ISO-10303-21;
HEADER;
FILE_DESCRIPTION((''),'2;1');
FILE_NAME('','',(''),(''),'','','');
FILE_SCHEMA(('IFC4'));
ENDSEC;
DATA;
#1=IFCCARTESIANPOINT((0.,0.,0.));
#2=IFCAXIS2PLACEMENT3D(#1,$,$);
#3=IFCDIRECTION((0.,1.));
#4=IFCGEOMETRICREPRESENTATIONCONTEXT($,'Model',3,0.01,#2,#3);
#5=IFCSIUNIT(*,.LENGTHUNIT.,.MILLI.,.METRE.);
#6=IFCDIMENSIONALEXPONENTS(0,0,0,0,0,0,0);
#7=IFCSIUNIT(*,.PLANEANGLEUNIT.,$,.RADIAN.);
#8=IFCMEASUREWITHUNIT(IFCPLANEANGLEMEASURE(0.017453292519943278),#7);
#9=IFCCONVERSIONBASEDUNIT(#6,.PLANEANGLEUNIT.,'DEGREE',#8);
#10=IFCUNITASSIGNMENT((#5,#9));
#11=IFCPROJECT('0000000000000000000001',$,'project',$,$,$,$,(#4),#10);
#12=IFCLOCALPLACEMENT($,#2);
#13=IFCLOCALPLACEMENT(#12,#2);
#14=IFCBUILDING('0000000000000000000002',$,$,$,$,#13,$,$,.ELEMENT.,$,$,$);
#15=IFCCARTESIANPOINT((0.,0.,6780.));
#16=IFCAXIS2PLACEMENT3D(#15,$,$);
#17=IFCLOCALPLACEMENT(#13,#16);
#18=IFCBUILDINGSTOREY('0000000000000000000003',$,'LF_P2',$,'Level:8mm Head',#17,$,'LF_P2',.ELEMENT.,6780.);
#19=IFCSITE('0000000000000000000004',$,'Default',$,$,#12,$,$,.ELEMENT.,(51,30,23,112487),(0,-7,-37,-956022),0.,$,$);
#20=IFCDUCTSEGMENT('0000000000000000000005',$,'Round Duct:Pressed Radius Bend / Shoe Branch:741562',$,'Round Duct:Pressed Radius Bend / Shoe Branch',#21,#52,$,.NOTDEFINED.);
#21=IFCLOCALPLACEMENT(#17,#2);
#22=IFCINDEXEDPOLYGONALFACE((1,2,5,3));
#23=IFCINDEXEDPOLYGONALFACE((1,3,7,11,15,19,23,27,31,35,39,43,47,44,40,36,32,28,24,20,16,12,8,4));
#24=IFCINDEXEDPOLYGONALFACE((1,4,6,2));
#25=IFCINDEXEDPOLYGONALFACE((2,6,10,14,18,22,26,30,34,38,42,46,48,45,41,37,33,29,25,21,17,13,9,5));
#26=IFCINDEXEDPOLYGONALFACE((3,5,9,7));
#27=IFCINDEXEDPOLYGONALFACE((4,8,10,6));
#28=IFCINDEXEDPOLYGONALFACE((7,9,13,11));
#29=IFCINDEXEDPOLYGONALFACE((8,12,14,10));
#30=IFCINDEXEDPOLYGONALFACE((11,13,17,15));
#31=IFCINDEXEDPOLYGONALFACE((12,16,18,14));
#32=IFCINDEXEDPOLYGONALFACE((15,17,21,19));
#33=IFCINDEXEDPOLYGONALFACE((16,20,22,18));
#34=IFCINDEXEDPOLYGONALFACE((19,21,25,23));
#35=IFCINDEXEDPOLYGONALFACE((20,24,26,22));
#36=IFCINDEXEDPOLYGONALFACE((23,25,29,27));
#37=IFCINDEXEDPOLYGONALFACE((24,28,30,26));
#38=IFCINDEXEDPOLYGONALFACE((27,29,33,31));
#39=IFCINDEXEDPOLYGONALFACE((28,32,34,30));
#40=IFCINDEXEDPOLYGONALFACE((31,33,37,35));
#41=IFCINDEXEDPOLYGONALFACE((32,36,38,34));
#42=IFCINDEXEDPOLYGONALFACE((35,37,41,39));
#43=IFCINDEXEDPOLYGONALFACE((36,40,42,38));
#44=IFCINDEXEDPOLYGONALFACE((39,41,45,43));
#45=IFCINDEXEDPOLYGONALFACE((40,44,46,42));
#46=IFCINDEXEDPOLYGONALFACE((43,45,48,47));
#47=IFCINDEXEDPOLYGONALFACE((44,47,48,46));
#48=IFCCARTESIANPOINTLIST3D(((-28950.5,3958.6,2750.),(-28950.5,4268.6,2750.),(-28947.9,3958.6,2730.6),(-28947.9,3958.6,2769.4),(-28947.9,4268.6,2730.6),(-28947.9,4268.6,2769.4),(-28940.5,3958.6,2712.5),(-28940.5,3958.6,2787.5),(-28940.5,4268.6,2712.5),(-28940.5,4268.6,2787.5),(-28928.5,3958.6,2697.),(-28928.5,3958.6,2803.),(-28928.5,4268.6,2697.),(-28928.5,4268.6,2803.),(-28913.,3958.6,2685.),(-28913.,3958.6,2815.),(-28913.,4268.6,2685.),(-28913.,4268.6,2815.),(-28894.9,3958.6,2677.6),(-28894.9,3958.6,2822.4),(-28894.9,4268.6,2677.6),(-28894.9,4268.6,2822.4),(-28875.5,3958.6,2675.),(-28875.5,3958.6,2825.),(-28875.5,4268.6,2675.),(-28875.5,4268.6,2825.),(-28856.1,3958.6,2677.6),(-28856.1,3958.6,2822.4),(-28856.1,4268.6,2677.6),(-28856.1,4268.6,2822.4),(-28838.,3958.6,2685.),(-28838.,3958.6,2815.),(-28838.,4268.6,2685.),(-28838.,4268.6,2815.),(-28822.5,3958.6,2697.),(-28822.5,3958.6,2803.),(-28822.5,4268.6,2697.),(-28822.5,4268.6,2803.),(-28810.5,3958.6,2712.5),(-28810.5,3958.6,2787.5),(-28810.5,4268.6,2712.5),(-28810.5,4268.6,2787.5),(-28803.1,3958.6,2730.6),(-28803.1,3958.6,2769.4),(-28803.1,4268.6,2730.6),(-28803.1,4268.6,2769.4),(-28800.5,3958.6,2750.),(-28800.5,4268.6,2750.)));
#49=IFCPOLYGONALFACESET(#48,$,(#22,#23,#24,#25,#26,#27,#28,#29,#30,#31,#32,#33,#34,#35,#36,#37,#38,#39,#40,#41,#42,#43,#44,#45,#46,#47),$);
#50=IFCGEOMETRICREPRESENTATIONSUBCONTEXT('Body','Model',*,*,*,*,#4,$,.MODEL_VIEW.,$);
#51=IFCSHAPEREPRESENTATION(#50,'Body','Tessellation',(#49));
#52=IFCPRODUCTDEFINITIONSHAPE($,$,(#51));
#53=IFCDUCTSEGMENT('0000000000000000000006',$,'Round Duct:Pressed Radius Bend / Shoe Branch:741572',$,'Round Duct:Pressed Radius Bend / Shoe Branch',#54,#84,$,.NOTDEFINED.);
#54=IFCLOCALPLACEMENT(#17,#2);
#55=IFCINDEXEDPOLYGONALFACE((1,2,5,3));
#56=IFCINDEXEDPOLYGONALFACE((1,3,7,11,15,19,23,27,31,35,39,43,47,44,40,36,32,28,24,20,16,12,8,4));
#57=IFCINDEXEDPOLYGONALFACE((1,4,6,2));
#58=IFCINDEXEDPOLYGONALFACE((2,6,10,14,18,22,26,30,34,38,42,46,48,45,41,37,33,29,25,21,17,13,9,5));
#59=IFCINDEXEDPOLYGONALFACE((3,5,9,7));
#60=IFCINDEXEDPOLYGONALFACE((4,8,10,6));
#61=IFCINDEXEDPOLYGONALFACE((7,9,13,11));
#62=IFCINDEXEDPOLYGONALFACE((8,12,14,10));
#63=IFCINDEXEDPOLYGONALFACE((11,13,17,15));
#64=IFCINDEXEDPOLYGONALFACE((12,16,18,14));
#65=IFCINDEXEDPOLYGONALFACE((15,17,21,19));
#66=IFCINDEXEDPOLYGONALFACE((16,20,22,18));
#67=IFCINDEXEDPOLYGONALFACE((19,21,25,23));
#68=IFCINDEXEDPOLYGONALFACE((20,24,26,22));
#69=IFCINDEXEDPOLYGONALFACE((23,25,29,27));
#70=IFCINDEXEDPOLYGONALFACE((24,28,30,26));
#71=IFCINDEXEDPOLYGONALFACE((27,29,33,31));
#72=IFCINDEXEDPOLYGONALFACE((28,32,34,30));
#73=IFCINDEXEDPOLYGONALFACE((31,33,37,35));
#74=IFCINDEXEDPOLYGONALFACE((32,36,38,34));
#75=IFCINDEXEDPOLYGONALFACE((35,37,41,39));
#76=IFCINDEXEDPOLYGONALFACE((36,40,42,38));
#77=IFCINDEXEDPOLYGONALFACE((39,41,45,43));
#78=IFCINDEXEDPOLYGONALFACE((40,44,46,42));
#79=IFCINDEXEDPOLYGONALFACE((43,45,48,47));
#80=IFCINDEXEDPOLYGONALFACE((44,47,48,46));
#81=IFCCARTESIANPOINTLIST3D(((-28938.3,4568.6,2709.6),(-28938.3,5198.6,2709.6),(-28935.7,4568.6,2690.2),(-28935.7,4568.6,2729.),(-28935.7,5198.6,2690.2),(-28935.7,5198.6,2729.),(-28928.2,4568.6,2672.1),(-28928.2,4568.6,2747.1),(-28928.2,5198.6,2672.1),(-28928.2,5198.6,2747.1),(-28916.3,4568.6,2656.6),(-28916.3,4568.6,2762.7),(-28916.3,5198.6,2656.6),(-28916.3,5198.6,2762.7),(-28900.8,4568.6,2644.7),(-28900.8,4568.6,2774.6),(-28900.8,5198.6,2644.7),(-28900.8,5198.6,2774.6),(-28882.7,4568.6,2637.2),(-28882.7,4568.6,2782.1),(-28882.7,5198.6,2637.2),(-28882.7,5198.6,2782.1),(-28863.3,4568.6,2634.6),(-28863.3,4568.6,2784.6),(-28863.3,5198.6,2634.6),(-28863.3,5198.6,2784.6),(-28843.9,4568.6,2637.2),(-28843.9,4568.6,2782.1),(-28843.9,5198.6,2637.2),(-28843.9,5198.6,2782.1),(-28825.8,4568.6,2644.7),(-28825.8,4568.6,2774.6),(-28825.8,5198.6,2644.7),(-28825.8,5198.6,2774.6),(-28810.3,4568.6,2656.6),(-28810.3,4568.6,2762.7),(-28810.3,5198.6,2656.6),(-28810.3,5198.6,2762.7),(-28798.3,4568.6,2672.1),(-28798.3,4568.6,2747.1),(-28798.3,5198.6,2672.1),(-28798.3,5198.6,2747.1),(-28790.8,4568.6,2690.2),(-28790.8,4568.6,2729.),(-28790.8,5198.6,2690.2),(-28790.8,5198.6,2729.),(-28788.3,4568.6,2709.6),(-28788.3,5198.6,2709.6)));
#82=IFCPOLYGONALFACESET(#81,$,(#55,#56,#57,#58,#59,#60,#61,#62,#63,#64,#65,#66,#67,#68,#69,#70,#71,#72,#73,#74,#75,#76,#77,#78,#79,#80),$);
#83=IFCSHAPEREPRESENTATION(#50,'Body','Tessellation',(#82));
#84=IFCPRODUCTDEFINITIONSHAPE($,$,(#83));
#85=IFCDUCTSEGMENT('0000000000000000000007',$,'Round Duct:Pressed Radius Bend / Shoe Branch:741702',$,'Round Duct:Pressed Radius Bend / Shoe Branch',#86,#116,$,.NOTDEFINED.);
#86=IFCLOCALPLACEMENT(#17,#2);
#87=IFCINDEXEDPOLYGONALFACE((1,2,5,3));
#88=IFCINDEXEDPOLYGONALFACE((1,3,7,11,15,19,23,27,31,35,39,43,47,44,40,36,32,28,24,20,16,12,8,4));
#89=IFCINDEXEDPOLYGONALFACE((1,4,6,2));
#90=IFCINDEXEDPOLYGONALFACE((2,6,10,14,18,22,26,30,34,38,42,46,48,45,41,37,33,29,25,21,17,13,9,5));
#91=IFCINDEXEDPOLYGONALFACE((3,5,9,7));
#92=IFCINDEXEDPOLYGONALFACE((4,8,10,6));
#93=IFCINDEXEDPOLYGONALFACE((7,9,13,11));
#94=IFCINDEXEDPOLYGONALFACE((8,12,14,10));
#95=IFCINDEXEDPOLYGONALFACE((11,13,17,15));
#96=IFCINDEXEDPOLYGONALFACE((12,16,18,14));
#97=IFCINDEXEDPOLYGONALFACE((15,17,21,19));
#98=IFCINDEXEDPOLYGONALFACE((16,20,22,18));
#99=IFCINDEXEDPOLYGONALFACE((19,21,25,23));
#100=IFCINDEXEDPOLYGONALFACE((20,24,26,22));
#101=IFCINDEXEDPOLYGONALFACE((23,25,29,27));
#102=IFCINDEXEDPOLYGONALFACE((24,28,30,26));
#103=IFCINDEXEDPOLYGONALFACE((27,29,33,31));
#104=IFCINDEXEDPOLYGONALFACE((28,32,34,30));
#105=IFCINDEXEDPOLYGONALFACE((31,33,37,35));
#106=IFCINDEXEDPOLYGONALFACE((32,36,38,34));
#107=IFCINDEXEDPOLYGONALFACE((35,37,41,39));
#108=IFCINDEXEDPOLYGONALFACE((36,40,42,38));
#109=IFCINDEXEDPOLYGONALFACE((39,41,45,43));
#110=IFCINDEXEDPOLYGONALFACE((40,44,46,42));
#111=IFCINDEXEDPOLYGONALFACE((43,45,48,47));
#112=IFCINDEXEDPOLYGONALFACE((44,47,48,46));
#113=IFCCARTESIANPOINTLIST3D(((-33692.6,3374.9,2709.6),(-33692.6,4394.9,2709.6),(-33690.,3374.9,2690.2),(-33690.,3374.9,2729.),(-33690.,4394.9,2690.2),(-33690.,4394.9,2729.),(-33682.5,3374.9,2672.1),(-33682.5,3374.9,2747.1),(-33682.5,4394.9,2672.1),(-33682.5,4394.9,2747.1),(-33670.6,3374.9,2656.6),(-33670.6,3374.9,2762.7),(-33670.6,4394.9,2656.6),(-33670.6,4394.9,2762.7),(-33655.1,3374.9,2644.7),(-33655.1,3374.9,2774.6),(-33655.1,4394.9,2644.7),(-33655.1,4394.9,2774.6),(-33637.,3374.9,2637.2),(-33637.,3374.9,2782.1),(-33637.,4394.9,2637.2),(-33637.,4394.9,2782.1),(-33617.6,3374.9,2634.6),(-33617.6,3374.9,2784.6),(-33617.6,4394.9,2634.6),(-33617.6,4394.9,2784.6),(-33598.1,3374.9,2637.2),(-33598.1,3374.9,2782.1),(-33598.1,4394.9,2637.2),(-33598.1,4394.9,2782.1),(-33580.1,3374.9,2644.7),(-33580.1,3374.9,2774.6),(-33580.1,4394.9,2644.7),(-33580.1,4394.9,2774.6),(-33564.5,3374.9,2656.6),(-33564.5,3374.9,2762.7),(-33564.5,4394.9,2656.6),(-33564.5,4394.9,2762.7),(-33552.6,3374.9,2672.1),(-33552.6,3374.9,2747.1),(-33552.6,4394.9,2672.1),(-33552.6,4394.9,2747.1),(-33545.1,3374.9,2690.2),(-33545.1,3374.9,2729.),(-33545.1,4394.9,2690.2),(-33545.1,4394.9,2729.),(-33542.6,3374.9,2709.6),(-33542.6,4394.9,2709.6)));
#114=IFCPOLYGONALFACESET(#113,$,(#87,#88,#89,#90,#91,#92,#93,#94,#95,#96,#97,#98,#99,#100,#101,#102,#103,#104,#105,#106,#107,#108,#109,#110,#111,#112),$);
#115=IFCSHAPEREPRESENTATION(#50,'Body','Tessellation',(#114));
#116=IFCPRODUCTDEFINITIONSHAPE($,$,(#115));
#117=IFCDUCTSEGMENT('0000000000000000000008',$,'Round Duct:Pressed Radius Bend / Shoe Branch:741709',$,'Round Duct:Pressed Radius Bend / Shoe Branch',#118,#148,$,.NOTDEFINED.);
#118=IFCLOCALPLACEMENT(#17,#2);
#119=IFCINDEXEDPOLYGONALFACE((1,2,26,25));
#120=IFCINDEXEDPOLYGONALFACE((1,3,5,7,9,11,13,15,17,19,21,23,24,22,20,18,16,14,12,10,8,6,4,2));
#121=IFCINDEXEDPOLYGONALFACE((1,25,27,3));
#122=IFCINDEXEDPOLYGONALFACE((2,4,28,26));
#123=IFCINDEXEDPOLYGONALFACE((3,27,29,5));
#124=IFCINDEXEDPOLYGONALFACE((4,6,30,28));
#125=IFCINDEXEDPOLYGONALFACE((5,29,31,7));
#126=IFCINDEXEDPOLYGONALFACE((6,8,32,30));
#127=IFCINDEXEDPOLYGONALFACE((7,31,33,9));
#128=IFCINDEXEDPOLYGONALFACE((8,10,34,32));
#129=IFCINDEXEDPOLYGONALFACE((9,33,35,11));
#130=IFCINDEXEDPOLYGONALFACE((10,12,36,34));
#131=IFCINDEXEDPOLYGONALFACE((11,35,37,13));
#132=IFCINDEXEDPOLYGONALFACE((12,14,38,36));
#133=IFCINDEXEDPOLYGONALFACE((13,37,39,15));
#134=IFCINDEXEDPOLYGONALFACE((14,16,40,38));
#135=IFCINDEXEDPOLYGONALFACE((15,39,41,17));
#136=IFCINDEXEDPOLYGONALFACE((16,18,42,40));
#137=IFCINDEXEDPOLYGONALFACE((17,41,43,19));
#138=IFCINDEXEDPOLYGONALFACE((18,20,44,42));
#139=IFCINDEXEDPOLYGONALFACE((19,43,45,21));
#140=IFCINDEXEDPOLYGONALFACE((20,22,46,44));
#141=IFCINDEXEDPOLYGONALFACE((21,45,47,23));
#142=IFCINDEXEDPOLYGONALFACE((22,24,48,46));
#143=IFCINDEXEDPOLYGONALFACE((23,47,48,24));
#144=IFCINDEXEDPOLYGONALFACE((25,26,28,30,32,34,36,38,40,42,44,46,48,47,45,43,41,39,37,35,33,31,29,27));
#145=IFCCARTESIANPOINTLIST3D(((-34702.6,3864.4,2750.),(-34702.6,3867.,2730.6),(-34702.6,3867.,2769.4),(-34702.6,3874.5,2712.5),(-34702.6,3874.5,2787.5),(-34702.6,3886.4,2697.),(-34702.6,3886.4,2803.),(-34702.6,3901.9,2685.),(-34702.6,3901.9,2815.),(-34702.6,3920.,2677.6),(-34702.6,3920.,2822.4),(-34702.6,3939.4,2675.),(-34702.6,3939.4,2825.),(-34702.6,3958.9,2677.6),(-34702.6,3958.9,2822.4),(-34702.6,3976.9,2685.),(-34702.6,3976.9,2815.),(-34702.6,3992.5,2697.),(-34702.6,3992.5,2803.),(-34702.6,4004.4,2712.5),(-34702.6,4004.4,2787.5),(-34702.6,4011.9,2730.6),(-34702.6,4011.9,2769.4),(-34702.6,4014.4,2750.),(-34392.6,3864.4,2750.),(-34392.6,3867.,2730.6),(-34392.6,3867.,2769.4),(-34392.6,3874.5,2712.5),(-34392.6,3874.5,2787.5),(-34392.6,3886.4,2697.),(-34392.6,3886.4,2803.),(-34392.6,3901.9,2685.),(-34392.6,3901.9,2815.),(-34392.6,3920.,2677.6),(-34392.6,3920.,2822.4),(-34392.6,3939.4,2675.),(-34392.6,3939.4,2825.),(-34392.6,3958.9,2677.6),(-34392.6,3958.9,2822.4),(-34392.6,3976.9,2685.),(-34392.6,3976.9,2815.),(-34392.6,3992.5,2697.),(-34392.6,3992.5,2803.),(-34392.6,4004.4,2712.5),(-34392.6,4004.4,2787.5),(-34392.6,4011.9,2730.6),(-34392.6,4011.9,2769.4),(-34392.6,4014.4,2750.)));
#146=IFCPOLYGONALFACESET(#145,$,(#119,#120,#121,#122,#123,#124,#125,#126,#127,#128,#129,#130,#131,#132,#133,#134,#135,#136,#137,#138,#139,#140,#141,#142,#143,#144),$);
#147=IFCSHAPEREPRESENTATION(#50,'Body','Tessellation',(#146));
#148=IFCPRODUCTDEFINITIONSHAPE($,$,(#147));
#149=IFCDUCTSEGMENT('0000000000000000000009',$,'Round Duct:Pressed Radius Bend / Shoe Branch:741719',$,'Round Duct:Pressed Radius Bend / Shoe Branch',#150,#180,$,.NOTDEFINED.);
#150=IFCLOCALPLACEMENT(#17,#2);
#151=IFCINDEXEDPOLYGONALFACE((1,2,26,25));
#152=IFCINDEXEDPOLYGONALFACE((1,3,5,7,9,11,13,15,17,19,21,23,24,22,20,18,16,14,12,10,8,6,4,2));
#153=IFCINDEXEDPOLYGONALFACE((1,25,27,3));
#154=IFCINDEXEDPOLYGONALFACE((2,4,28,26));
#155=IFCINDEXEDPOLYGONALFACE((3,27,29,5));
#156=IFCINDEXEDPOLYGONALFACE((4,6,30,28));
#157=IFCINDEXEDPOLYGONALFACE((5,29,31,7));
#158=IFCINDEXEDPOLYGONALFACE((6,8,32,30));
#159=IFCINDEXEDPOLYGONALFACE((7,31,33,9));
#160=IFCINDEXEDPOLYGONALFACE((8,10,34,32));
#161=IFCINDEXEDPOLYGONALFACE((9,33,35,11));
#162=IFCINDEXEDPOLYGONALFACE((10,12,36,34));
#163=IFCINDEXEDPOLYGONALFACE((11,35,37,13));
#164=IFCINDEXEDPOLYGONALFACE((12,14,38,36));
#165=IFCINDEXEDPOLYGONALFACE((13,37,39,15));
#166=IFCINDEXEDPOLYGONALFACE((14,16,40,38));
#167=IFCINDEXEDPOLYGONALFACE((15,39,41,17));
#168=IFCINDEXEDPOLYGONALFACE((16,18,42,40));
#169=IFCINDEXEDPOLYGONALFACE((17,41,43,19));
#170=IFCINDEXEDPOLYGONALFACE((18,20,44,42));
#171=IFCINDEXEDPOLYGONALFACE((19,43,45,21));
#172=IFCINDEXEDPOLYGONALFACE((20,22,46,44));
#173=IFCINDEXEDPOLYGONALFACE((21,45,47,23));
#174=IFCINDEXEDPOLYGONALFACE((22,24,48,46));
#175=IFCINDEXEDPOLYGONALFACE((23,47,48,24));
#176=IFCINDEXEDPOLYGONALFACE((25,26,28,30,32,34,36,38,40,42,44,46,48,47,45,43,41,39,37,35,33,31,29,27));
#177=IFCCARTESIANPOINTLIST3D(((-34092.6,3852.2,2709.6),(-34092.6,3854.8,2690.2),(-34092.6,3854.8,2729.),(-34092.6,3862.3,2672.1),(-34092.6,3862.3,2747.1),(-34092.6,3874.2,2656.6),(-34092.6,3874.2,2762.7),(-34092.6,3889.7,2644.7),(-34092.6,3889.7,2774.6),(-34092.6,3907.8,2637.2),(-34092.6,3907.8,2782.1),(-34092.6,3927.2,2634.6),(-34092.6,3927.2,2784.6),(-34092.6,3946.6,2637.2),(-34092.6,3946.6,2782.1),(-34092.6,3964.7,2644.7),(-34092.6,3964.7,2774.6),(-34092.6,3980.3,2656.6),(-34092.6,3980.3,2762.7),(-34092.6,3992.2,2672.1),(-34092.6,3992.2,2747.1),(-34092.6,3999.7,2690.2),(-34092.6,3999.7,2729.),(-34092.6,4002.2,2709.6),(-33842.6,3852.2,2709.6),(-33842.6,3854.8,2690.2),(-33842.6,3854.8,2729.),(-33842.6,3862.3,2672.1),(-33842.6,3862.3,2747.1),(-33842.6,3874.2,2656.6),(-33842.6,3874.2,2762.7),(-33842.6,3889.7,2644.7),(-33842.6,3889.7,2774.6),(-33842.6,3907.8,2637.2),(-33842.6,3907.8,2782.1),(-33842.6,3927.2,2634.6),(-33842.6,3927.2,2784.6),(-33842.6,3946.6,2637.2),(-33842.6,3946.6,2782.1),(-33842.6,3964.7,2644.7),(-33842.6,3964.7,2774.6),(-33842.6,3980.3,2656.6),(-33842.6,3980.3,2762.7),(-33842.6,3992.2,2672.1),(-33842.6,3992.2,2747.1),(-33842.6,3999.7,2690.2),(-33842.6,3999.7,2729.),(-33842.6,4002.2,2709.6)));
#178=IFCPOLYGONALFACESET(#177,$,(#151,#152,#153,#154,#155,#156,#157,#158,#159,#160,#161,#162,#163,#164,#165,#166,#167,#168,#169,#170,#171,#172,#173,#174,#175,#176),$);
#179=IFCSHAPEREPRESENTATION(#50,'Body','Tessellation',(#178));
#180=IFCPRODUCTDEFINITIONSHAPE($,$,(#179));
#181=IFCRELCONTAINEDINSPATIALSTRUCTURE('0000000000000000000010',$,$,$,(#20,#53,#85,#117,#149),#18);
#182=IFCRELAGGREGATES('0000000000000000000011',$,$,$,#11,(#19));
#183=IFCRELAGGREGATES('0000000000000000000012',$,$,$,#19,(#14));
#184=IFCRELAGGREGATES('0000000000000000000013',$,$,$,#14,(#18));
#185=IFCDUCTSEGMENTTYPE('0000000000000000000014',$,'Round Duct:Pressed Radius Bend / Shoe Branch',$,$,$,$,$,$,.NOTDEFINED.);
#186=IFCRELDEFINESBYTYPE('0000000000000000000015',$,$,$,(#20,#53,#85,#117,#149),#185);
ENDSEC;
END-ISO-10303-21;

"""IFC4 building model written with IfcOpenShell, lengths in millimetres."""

from ifc_helpers import new_model, entity, si_unit, converted_unit, direction, frame, origin, place, context, subcontext, project, spatial, arc, indexed_curve, outline, extrude, type_object, element, save


model = new_model("IFC4")

# Units and contexts
model_context = context("Model", 3, precision=0.01, world=origin(), true_north=direction((0.0, 1.0)))
body_context = subcontext(model_context, "Body", "Model", "MODEL_VIEW")
ifc_project = project(units=[si_unit("LENGTHUNIT", "METRE", prefix="MILLI"), converted_unit("PLANEANGLEUNIT", "DEGREE", entity("IfcPlaneAngleMeasure", 0.017453292519943278), si_unit("PLANEANGLEUNIT", "RADIAN"), dimensions=[0, 0, 0, 0, 0, 0, 0])], contexts=[model_context])

# Site, building, storey
site_placement = place(None, origin())
site = spatial("IfcSite", under=ifc_project, at=site_placement, Name="Default", CompositionType="ELEMENT", RefLatitude=(51, 30, 23, 112487), RefLongitude=(0, -7, -37, -956022), RefElevation=0.0)
building_placement = place(site_placement, origin())
building = spatial("IfcBuilding", under=site, at=building_placement, CompositionType="ELEMENT")
storey_placement = place(building_placement, frame((0.0, 0.0, 6780.0)))
storey = spatial("IfcBuildingStorey", under=building, at=storey_placement, Name="LF_P2", ObjectType="Level:8mm Head", LongName="LF_P2", CompositionType="ELEMENT", Elevation=6780.0)

# Duct segments
duct_segment_type_1 = type_object("IfcDuctSegmentType", Name="Round Duct:Pressed Radius Bend / Shoe Branch", PredefinedType="NOTDEFINED")
duct_segment_1_placement = place(storey_placement, origin())
element("IfcDuctSegment", 1, at=duct_segment_1_placement, inside=storey, type_object=duct_segment_type_1, Name="Round Duct:Pressed Radius Bend / Shoe Branch:741562", ObjectType="Round Duct:Pressed Radius Bend / Shoe Branch", PredefinedType="NOTDEFINED", context=body_context, shape_type="SweptSolid", body=[
    extrude(outline(indexed_curve([(75.0, 0.0), (53.0, 53.0), (0.0, 75.0), (-53.0, 53.0), (-75.0, 0.0), (-53.0, -53.0), (0.0, -75.0), (53.0, -53.0)], segments=[arc(1, 2, 3), arc(3, 4, 5), arc(5, 6, 7), arc(7, 8, 1)], self_intersect=False)), frame((-28875.5, 3958.6, 2750.0), z_axis=(0.0, 1.0, 0.0), x_axis=(1.0, 0.0, 0.0)), (0.0, 0.0, 1.0), 310.0),
])
duct_segment_2_placement = place(storey_placement, origin())
element("IfcDuctSegment", 2, at=duct_segment_2_placement, inside=storey, type_object=duct_segment_type_1, Name="Round Duct:Pressed Radius Bend / Shoe Branch:741572", ObjectType="Round Duct:Pressed Radius Bend / Shoe Branch", PredefinedType="NOTDEFINED", context=body_context, shape_type="SweptSolid", body=[
    extrude(outline(indexed_curve([(75.0, 0.0), (53.0, 53.0), (0.0, 75.0), (-53.0, 53.0), (-75.0, 0.0), (-53.0, -53.0), (0.0, -75.0), (53.0, -53.0)], segments=[arc(1, 2, 3), arc(3, 4, 5), arc(5, 6, 7), arc(7, 8, 1)], self_intersect=False)), frame((-28863.3, 4568.6, 2709.6), z_axis=(0.0, 1.0, 0.0), x_axis=(-1.0, 0.0, 0.0)), (0.0, 0.0, 1.0), 630.0),
])
duct_segment_3_placement = place(storey_placement, origin())
element("IfcDuctSegment", 3, at=duct_segment_3_placement, inside=storey, type_object=duct_segment_type_1, Name="Round Duct:Pressed Radius Bend / Shoe Branch:741702", ObjectType="Round Duct:Pressed Radius Bend / Shoe Branch", PredefinedType="NOTDEFINED", context=body_context, shape_type="SweptSolid", body=[
    extrude(outline(indexed_curve([(75.0, 0.0), (53.0, 53.0), (0.0, 75.0), (-53.0, 53.0), (-75.0, 0.0), (-53.0, -53.0), (0.0, -75.0), (53.0, -53.0)], segments=[arc(1, 2, 3), arc(3, 4, 5), arc(5, 6, 7), arc(7, 8, 1)], self_intersect=False)), frame((-33617.6, 3374.9, 2709.6), z_axis=(0.0, 1.0, 0.0), x_axis=(-1.0, 0.0, 0.0)), (0.0, 0.0, 1.0), 1020.0),
])
duct_segment_4_placement = place(storey_placement, origin())
element("IfcDuctSegment", 4, at=duct_segment_4_placement, inside=storey, type_object=duct_segment_type_1, Name="Round Duct:Pressed Radius Bend / Shoe Branch:741709", ObjectType="Round Duct:Pressed Radius Bend / Shoe Branch", PredefinedType="NOTDEFINED", context=body_context, shape_type="SweptSolid", body=[
    extrude(outline(indexed_curve([(75.0, 0.0), (53.0, 53.0), (0.0, 75.0), (-53.0, 53.0), (-75.0, 0.0), (-53.0, -53.0), (0.0, -75.0), (53.0, -53.0)], segments=[arc(1, 2, 3), arc(3, 4, 5), arc(5, 6, 7), arc(7, 8, 1)], self_intersect=False)), frame((-34702.6, 3939.4, 2750.0), z_axis=(1.0, 0.0, 0.0), x_axis=(0.0, -1.0, 0.0)), (0.0, 0.0, 1.0), 310.0),
])
duct_segment_5_placement = place(storey_placement, origin())
element("IfcDuctSegment", 5, at=duct_segment_5_placement, inside=storey, type_object=duct_segment_type_1, Name="Round Duct:Pressed Radius Bend / Shoe Branch:741719", ObjectType="Round Duct:Pressed Radius Bend / Shoe Branch", PredefinedType="NOTDEFINED", context=body_context, shape_type="SweptSolid", body=[
    extrude(outline(indexed_curve([(75.0, 0.0), (53.0, 53.0), (0.0, 75.0), (-53.0, 53.0), (-75.0, 0.0), (-53.0, -53.0), (0.0, -75.0), (53.0, -53.0)], segments=[arc(1, 2, 3), arc(3, 4, 5), arc(5, 6, 7), arc(7, 8, 1)], self_intersect=False)), frame((-34092.6, 3927.2, 2709.6), z_axis=(1.0, 0.0, 0.0), x_axis=(0.0, 1.0, 0.0)), (0.0, 0.0, 1.0), 250.0),
])

save(model, "model.ifc")
